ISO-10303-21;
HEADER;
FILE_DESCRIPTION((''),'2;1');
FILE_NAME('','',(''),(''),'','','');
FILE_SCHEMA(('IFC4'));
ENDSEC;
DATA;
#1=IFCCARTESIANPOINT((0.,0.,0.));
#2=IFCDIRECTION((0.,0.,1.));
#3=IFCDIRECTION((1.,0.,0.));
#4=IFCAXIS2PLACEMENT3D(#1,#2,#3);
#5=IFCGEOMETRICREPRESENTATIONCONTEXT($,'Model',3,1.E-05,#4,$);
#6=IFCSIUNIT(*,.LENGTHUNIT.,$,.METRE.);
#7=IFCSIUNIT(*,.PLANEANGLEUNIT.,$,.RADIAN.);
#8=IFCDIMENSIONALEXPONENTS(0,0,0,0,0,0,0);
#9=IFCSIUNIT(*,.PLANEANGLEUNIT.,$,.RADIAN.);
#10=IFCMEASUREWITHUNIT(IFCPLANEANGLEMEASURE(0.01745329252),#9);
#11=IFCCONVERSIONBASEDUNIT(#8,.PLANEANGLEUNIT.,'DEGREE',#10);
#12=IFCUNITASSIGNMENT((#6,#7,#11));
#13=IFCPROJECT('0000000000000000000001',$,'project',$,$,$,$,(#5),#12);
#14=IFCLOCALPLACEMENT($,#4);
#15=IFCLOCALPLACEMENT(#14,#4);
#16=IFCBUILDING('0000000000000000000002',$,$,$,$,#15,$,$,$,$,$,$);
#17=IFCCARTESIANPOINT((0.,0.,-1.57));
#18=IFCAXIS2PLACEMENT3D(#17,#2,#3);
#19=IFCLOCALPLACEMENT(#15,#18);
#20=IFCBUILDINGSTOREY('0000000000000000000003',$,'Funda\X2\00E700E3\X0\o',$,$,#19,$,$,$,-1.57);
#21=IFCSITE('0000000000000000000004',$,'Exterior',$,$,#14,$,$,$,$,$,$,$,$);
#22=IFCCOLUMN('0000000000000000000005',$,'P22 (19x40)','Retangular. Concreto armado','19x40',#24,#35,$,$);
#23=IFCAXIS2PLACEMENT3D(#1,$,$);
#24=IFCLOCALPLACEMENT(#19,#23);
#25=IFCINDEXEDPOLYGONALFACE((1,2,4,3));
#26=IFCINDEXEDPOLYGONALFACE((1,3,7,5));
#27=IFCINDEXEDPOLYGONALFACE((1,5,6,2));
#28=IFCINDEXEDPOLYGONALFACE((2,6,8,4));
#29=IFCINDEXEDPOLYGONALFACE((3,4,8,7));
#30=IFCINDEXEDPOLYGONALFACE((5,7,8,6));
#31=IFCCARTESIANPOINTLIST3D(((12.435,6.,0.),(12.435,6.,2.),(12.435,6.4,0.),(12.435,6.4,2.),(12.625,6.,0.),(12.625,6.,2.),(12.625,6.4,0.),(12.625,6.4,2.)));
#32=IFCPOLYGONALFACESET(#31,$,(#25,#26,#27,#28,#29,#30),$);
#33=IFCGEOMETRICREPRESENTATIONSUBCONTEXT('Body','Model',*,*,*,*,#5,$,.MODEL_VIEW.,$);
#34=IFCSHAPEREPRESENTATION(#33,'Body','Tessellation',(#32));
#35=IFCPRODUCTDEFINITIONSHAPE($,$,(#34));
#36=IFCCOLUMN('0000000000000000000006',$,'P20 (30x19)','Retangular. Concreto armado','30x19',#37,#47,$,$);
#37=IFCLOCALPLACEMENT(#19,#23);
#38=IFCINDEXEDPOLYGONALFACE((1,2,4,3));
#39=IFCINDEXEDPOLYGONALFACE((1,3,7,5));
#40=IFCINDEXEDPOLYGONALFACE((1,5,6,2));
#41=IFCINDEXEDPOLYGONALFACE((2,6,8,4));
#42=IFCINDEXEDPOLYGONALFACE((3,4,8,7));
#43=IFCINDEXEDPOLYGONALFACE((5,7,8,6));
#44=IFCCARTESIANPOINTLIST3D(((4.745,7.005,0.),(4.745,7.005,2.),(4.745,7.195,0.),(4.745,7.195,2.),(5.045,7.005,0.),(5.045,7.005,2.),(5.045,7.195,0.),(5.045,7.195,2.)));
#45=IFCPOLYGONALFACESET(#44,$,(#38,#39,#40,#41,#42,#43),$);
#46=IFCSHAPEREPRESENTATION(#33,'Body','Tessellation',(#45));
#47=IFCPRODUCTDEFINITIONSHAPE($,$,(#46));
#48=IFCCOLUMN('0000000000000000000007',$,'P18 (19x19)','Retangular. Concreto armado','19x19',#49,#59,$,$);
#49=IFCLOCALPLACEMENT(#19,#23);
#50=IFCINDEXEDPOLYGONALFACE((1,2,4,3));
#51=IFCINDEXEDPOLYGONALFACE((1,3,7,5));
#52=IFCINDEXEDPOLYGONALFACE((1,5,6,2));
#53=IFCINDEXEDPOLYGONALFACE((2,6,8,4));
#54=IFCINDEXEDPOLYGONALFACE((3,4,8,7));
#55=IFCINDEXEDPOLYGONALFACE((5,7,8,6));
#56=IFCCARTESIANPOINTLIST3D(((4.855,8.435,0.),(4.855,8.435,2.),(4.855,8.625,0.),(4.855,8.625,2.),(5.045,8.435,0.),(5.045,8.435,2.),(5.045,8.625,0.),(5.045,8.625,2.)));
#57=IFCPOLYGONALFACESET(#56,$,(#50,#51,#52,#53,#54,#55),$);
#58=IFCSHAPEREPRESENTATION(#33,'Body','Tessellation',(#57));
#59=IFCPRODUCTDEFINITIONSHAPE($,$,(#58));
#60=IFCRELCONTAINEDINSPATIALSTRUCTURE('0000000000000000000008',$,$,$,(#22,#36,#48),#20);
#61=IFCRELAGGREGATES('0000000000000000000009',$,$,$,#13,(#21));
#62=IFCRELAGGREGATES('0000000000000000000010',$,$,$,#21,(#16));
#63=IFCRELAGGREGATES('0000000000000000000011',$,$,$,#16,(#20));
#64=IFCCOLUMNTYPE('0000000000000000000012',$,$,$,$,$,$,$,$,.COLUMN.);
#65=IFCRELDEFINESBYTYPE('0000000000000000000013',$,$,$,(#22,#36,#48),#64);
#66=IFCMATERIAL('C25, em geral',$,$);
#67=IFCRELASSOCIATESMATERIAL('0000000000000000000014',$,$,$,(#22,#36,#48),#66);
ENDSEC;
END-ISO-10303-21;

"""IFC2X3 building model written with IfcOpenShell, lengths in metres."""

from ifc_helpers import new_model, entity, si_unit, converted_unit, frame, frame_2d, origin_with_axes, place, context, subcontext, project, spatial, rectangle, extrude, material, type_object, element, save


model = new_model("IFC2X3")

# Units and contexts
model_context = context("Model", 3, precision=1e-05, world=origin_with_axes())
body_context = subcontext(model_context, "Body", "Model", "MODEL_VIEW")
ifc_project = project(units=[si_unit("LENGTHUNIT", "METRE"), si_unit("PLANEANGLEUNIT", "RADIAN"), converted_unit("PLANEANGLEUNIT", "DEGREE", entity("IfcPlaneAngleMeasure", 0.01745329252), si_unit("PLANEANGLEUNIT", "RADIAN"), dimensions=[0, 0, 0, 0, 0, 0, 0])], contexts=[model_context])

# Site, building, storey
site_placement = place(None, origin_with_axes())
site = spatial("IfcSite", under=ifc_project, at=site_placement, Name="Exterior")
building_placement = place(site_placement, origin_with_axes())
building = spatial("IfcBuilding", under=site, at=building_placement)
storey_placement = place(building_placement, frame((0.0, 0.0, -1.57), z_axis=(0.0, 0.0, 1.0), x_axis=(1.0, 0.0, 0.0)))
storey = spatial("IfcBuildingStorey", under=building, at=storey_placement, Name="Fundação", Elevation=-1.57)

# Columns
ifc_material_1 = material(Name="C25, em geral")
column_type = type_object("IfcColumnType", PredefinedType="COLUMN")
column_1_placement = place(storey_placement, frame((12.625, 6.0, 0.0), z_axis=(0.0, 0.0, 1.0), x_axis=(1.0, 0.0, 0.0)))
element("IfcColumn", 1, at=column_1_placement, inside=storey, type_object=column_type, material=ifc_material_1, Name="P22 (19x40)", Description="Retangular. Concreto armado", ObjectType="19x40", context=body_context, shape_type="SweptSolid", body=[
    extrude(rectangle(XDim=0.19, YDim=0.4, at=frame_2d((-0.095, 0.2), x_axis=(1.0, 0.0))), origin_with_axes(), (0.0, 0.0, 1.0), 2.0),
])
column_2_placement = place(storey_placement, frame((5.045, 7.005, 0.0), z_axis=(0.0, 0.0, 1.0), x_axis=(1.0, 0.0, 0.0)))
element("IfcColumn", 2, at=column_2_placement, inside=storey, type_object=column_type, material=ifc_material_1, Name="P20 (30x19)", Description="Retangular. Concreto armado", ObjectType="30x19", context=body_context, shape_type="SweptSolid", body=[
    extrude(rectangle(XDim=0.3, YDim=0.19, at=frame_2d((-0.15, 0.095), x_axis=(1.0, 0.0))), origin_with_axes(), (0.0, 0.0, 1.0), 2.0),
])
column_3_placement = place(storey_placement, frame((5.045, 8.625, 0.0), z_axis=(0.0, 0.0, 1.0), x_axis=(1.0, 0.0, 0.0)))
element("IfcColumn", 3, at=column_3_placement, inside=storey, type_object=column_type, material=ifc_material_1, Name="P18 (19x19)", Description="Retangular. Concreto armado", ObjectType="19x19", context=body_context, shape_type="SweptSolid", body=[
    extrude(rectangle(XDim=0.19, YDim=0.19, at=frame_2d((-0.095, -0.095), x_axis=(1.0, 0.0))), origin_with_axes(), (0.0, 0.0, 1.0), 2.0),
])

save(model, "model.ifc")
